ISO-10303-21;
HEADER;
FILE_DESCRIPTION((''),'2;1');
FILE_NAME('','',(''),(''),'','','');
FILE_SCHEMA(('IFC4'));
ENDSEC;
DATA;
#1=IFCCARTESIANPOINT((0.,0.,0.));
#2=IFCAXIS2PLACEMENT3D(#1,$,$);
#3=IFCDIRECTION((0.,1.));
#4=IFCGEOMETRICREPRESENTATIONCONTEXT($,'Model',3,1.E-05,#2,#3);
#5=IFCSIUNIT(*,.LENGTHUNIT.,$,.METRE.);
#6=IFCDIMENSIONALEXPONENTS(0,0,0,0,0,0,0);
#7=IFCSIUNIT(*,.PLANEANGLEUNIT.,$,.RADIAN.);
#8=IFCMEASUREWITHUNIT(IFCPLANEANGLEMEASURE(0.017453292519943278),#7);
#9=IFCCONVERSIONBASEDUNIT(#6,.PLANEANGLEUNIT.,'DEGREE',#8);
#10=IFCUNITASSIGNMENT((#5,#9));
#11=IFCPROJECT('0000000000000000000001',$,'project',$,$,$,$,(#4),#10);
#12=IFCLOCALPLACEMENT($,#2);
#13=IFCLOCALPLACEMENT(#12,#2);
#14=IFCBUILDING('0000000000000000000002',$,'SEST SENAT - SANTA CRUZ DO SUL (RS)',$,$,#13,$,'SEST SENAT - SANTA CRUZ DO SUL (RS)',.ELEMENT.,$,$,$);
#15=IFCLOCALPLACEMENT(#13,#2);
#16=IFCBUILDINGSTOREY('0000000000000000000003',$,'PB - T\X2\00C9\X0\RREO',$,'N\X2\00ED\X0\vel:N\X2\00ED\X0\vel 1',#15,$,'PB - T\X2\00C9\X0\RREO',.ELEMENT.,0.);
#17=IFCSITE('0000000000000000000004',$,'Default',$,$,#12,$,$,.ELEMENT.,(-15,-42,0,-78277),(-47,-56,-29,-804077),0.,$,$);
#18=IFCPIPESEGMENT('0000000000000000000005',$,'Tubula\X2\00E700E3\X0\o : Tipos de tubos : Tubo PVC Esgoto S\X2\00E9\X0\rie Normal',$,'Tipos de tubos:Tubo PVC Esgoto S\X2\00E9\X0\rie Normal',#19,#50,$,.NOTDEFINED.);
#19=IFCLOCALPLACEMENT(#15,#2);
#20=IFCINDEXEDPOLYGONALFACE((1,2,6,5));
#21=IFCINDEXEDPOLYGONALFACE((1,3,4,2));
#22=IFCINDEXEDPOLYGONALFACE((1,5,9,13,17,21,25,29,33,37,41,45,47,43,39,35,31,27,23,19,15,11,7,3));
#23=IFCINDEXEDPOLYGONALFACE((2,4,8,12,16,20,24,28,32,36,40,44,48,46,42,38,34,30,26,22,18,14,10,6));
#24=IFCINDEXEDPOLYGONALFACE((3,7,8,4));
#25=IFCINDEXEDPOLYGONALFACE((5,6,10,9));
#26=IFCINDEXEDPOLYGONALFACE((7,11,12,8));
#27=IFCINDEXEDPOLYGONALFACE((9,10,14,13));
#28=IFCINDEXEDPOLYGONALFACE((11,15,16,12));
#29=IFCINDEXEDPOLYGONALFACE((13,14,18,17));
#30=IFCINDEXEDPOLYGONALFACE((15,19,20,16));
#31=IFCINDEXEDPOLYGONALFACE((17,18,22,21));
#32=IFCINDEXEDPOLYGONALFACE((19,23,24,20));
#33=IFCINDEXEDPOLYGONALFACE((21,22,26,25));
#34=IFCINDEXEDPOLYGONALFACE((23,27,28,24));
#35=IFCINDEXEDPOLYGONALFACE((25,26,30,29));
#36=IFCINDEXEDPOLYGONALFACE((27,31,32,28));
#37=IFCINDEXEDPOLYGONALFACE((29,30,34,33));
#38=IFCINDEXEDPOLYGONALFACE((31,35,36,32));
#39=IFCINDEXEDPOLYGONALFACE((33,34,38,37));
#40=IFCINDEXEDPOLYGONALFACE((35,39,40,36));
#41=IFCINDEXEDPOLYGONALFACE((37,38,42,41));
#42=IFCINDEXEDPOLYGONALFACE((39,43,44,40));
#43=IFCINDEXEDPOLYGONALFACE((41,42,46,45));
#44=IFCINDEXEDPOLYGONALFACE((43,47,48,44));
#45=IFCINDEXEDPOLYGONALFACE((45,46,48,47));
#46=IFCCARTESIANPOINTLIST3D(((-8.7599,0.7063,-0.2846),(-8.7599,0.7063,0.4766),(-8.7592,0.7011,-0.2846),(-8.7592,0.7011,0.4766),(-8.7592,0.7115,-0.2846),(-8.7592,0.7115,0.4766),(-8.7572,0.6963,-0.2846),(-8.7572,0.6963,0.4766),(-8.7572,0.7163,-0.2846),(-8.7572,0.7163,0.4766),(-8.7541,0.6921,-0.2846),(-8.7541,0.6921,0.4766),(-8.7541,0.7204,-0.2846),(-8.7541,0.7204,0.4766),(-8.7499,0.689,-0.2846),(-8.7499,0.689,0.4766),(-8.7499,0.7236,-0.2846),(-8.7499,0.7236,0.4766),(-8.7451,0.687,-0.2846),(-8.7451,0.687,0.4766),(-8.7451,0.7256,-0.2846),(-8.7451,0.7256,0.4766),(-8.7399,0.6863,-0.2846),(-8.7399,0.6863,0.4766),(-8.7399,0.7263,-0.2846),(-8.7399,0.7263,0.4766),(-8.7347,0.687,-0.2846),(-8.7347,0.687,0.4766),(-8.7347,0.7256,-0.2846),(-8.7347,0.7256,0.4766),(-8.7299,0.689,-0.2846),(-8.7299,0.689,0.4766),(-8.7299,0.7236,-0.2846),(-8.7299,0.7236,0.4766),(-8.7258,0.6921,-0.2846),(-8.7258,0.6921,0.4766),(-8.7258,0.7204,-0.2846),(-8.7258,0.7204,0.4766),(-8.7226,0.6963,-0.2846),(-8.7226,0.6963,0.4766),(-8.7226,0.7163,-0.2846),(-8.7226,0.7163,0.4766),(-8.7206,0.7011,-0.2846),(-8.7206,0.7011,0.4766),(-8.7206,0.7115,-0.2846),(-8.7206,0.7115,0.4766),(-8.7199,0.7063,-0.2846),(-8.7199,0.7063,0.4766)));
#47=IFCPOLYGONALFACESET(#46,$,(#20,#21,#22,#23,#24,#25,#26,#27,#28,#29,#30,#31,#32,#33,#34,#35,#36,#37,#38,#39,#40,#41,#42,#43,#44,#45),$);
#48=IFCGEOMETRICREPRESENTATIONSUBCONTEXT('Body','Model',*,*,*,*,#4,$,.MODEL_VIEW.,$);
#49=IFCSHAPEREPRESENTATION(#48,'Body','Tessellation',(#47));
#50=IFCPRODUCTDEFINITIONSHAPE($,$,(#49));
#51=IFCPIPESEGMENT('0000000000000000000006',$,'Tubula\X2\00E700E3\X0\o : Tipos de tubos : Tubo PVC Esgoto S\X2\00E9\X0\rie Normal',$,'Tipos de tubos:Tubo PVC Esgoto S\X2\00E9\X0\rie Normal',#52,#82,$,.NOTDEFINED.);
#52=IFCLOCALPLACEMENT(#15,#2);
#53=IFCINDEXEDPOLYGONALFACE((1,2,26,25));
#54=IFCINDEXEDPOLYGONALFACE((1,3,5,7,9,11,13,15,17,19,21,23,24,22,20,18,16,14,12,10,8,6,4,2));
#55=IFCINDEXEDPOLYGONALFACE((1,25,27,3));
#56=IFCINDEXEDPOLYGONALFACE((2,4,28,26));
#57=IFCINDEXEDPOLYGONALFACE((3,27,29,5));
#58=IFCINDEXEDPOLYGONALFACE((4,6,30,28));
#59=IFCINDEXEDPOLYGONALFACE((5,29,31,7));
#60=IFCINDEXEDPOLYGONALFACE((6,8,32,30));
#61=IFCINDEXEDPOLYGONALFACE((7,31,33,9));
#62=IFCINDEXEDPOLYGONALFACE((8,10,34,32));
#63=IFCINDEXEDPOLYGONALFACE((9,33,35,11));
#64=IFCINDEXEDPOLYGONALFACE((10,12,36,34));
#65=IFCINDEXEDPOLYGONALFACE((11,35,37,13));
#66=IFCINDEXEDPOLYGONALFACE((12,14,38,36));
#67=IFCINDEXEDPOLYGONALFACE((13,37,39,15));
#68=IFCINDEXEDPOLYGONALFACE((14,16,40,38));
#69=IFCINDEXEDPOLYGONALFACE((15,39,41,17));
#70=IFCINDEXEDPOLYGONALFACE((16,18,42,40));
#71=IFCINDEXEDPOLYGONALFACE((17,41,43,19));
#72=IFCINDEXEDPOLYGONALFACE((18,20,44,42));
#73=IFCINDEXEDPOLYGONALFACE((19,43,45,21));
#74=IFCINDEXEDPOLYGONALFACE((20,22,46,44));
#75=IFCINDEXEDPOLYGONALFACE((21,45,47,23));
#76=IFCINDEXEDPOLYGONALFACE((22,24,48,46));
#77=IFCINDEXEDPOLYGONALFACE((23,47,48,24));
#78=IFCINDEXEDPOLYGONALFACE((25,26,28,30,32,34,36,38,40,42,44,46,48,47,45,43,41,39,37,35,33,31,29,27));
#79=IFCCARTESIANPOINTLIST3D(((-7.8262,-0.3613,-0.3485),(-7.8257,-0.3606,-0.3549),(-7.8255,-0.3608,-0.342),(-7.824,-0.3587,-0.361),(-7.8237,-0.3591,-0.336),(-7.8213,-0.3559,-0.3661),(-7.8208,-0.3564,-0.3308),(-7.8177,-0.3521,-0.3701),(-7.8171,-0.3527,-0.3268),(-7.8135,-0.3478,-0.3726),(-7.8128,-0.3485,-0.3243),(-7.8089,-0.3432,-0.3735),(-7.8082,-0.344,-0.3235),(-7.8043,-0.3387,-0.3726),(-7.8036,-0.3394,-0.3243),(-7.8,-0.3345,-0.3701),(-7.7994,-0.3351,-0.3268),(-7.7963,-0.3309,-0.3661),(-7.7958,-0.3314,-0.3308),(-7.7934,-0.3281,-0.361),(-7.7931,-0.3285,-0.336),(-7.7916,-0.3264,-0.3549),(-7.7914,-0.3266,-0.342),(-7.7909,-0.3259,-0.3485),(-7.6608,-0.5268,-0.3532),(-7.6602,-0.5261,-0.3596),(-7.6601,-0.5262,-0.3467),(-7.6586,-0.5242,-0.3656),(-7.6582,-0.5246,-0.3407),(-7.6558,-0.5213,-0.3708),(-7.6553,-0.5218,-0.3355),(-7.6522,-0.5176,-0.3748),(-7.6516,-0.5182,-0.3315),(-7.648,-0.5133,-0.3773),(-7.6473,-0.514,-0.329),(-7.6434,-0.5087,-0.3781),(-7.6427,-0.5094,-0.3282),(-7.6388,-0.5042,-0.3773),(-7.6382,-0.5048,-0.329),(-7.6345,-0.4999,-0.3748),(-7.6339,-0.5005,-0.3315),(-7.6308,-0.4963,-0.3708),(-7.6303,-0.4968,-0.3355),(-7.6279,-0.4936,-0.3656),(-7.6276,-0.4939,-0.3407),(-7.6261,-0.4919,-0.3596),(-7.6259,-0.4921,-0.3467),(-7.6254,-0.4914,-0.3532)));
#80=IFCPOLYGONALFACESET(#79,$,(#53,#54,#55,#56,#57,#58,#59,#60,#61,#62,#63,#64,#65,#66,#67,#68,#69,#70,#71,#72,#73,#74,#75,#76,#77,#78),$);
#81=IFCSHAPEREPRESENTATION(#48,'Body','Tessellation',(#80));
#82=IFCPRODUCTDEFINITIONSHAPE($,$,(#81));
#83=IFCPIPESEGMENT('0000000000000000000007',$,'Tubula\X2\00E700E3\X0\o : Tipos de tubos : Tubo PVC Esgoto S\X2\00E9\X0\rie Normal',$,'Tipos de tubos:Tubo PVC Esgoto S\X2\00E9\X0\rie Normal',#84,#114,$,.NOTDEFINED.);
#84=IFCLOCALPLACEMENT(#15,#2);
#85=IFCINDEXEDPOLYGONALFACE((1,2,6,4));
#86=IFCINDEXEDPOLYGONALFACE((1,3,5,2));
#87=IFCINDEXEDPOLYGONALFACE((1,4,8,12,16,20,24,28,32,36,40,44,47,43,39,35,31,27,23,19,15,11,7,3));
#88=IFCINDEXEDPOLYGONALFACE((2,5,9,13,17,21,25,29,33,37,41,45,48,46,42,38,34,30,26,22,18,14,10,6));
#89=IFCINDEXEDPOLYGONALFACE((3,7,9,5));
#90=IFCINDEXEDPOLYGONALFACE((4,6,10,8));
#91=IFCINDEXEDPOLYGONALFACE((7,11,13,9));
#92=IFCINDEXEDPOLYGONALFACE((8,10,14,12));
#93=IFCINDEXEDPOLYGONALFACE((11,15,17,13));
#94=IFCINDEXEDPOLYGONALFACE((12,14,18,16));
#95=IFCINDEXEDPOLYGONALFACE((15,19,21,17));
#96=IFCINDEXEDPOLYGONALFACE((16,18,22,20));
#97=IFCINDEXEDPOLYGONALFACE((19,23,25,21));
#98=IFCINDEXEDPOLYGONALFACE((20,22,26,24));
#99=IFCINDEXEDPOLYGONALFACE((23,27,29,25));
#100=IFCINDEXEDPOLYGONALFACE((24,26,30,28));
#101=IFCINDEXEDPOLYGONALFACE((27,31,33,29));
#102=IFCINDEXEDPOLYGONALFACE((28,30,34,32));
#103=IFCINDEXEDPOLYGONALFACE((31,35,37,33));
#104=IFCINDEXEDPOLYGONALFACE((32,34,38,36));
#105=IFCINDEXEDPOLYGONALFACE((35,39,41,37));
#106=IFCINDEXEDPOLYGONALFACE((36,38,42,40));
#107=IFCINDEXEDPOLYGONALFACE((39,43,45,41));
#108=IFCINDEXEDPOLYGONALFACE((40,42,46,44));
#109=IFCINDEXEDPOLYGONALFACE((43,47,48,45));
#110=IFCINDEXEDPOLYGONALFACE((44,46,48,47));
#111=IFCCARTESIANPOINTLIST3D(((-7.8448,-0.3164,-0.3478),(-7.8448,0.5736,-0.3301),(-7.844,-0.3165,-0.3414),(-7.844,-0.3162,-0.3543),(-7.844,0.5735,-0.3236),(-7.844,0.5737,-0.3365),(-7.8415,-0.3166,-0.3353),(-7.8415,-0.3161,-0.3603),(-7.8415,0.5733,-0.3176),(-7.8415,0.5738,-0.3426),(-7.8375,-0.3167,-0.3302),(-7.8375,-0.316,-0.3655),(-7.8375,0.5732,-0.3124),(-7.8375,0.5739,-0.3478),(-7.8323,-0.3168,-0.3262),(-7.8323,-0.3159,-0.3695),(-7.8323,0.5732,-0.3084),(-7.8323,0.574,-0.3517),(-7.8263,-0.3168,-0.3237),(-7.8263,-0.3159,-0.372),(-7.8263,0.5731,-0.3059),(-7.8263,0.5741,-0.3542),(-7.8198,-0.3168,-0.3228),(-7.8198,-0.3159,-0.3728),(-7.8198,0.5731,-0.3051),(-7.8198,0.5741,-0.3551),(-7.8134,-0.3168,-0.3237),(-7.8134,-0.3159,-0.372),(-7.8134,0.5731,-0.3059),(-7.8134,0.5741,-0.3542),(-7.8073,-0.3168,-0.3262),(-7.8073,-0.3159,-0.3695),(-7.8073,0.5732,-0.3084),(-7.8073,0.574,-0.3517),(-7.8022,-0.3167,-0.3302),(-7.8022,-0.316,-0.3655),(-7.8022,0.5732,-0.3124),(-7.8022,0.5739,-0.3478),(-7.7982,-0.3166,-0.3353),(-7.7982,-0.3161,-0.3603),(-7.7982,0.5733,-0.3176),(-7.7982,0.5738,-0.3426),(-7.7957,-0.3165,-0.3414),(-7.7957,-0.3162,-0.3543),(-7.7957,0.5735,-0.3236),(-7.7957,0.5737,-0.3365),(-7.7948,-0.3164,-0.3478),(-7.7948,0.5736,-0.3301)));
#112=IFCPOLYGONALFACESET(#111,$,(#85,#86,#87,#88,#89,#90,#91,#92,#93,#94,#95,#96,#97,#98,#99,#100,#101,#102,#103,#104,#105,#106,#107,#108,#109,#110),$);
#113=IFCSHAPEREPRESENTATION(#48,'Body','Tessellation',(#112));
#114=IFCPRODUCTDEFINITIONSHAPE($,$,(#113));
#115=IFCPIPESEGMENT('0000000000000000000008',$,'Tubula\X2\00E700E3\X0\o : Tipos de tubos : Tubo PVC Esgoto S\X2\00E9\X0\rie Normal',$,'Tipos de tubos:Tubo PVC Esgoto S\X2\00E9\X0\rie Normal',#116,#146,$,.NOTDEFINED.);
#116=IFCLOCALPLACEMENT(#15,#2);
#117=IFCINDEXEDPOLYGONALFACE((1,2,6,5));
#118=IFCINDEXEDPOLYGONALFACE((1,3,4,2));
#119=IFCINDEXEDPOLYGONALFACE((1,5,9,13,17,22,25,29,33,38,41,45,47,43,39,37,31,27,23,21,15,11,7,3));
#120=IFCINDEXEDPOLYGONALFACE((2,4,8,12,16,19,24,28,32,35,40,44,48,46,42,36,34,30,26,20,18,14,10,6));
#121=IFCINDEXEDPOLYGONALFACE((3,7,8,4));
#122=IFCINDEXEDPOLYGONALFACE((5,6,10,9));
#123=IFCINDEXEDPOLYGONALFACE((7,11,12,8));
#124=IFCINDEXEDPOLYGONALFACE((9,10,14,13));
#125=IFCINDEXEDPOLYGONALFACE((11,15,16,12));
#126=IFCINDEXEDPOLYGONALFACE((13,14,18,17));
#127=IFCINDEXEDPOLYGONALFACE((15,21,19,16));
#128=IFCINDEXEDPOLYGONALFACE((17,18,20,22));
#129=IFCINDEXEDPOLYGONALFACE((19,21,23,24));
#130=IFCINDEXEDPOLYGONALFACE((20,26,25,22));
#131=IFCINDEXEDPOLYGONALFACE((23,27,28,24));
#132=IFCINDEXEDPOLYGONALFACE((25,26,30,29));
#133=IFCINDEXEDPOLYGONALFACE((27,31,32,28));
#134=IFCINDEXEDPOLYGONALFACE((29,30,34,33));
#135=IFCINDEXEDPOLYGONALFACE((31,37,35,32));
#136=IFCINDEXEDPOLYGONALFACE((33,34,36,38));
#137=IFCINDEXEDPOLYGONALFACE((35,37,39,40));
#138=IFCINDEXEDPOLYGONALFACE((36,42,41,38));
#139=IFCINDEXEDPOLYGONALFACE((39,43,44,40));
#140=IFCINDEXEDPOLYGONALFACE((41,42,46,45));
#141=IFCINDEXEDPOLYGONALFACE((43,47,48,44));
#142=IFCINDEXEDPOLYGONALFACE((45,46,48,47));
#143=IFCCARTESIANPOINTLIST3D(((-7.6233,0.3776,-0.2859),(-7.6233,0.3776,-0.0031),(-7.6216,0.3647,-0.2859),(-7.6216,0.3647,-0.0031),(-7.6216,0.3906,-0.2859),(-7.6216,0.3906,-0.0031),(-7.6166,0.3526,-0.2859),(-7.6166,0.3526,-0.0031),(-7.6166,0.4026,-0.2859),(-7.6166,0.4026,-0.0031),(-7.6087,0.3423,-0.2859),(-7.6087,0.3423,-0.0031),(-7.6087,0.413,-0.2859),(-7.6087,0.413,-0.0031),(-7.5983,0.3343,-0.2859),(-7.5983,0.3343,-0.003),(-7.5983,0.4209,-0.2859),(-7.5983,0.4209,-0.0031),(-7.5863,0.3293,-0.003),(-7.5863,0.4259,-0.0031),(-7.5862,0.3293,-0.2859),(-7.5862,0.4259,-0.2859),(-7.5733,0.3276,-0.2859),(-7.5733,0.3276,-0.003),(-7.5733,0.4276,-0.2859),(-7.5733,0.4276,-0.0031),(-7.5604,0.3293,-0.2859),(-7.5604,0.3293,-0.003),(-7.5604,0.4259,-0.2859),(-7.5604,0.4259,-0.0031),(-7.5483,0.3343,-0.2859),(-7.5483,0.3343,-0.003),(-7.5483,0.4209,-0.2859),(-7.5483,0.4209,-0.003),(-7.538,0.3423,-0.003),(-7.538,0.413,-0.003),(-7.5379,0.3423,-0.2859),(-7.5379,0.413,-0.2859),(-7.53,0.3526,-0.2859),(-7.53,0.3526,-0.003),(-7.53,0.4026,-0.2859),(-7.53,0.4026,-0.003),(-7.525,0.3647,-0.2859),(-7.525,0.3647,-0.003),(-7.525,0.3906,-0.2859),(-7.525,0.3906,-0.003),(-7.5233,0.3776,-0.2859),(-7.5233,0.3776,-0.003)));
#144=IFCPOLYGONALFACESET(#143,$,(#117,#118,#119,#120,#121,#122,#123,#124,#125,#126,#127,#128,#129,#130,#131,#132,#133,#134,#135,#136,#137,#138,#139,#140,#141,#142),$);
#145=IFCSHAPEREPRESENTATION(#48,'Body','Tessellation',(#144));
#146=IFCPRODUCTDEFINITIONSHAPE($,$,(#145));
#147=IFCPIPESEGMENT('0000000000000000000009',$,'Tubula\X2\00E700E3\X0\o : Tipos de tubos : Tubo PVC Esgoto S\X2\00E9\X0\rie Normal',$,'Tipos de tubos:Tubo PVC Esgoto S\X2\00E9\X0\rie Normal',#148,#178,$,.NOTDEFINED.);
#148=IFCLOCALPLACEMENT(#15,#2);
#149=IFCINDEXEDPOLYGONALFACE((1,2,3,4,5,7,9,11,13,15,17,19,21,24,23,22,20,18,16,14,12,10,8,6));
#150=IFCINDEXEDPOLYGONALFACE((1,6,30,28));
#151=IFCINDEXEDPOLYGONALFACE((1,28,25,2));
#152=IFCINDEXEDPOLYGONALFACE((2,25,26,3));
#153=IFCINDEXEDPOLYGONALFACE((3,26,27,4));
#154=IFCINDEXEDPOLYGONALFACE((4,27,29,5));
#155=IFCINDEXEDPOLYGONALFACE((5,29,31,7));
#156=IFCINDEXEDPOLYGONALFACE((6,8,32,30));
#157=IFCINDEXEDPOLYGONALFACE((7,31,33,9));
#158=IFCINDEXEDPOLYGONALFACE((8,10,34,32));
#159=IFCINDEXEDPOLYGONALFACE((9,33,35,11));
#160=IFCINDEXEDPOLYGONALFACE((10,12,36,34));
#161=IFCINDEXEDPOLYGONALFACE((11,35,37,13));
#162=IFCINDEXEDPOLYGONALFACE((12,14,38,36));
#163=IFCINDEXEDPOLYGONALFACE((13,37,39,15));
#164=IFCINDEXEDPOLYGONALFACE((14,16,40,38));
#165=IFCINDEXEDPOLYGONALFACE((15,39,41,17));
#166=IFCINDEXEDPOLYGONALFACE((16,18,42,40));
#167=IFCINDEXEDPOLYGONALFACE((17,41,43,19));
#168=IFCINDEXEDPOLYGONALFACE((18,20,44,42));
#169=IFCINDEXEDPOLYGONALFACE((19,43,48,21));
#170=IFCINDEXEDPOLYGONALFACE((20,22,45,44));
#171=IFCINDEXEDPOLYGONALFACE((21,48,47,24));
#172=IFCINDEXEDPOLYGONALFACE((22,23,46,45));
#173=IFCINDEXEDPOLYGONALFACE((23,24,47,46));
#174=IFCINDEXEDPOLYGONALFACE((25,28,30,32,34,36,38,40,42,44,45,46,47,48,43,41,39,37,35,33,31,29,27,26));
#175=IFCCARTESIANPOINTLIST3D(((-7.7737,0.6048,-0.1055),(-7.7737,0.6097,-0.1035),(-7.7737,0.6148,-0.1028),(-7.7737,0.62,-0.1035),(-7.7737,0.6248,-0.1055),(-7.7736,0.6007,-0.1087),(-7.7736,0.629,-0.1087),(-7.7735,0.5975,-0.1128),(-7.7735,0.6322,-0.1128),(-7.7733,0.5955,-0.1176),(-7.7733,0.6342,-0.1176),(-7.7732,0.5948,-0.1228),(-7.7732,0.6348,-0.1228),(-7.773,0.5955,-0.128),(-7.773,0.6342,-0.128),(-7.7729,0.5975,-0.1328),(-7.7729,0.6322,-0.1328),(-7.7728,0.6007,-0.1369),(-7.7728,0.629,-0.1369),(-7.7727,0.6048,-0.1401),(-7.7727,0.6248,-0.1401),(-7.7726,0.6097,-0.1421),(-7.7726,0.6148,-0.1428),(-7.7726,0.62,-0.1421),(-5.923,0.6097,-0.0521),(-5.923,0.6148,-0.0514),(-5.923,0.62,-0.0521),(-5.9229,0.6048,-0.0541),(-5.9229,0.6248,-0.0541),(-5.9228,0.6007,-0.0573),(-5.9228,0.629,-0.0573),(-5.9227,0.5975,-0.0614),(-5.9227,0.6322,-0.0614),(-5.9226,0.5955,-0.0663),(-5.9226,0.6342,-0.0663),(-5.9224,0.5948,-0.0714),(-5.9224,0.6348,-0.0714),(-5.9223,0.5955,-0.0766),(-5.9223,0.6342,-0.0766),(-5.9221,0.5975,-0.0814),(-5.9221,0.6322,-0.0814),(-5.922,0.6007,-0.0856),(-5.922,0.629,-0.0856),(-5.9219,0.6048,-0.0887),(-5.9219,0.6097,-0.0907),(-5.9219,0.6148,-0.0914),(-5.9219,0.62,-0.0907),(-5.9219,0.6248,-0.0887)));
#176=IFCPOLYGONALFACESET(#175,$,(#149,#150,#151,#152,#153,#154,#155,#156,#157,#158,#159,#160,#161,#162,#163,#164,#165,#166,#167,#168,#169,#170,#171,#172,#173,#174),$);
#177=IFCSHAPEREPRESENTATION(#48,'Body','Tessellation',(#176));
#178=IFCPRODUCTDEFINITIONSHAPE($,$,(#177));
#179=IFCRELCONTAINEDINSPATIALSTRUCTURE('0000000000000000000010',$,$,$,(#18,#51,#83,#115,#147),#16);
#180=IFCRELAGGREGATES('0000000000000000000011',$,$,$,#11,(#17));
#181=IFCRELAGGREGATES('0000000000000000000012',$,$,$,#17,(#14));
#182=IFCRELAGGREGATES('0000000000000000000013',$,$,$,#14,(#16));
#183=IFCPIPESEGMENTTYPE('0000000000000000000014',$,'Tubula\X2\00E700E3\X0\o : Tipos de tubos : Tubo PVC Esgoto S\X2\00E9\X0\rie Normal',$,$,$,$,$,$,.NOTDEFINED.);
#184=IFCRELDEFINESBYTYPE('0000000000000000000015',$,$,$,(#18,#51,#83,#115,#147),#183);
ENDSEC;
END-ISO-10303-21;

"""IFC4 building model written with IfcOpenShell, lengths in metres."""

from ifc_helpers import new_model, entity, si_unit, converted_unit, direction, frame, origin, place, context, subcontext, project, spatial, arc, indexed_curve, outline, extrude, type_object, element, save


model = new_model("IFC4")

# Units and contexts
model_context = context("Model", 3, precision=1e-05, world=origin(), true_north=direction((0.0, 1.0)))
body_context = subcontext(model_context, "Body", "Model", "MODEL_VIEW")
ifc_project = project(units=[si_unit("LENGTHUNIT", "METRE"), converted_unit("PLANEANGLEUNIT", "DEGREE", entity("IfcPlaneAngleMeasure", 0.017453292519943278), si_unit("PLANEANGLEUNIT", "RADIAN"), dimensions=[0, 0, 0, 0, 0, 0, 0])], contexts=[model_context])

# Site, building, storey
site_placement = place(None, origin())
site = spatial("IfcSite", under=ifc_project, at=site_placement, Name="Default", CompositionType="ELEMENT", RefLatitude=(-15, -42, 0, -78277), RefLongitude=(-47, -56, -29, -804077), RefElevation=0.0)
building_placement = place(site_placement, origin())
building = spatial("IfcBuilding", under=site, at=building_placement, Name="SEST SENAT - SANTA CRUZ DO SUL (RS)", LongName="SEST SENAT - SANTA CRUZ DO SUL (RS)", CompositionType="ELEMENT")
storey_placement = place(building_placement, origin())
storey = spatial("IfcBuildingStorey", under=building, at=storey_placement, Name="PB - TÉRREO", ObjectType="Nível:Nível 1", LongName="PB - TÉRREO", CompositionType="ELEMENT", Elevation=0.0)

# Pipe segments
pipe_segment_type_1 = type_object("IfcPipeSegmentType", Name="Tubulação : Tipos de tubos : Tubo PVC Esgoto Série Normal", PredefinedType="NOTDEFINED")
pipe_segment_1_placement = place(storey_placement, frame((-8.7615, 0.6847, -0.2846)))
element("IfcPipeSegment", 1, at=pipe_segment_1_placement, inside=storey, type_object=pipe_segment_type_1, Name="Tubulação : Tipos de tubos : Tubo PVC Esgoto Série Normal", ObjectType="Tipos de tubos:Tubo PVC Esgoto Série Normal", PredefinedType="NOTDEFINED", context=body_context, shape_type="SweptSolid", body=[
    extrude(outline(indexed_curve([(0.02, 0.0), (0.0141, 0.0141), (0.0, 0.02), (-0.0141, 0.0141), (-0.02, 0.0), (-0.0141, -0.0141), (0.0, -0.02), (0.0141, -0.0141)], segments=[arc(1, 2, 3), arc(3, 4, 5), arc(5, 6, 7), arc(7, 8, 1)], self_intersect=False)), frame((0.0216, 0.0216, 0.0), z_axis=(0.0, 0.0, 1.0), x_axis=(-1.0, 0.0, 0.0)), (0.0, 0.0, 1.0), 0.7613),
])
pipe_segment_2_placement = place(storey_placement, frame((-7.8278, -0.5283, -0.3219)))
element("IfcPipeSegment", 2, at=pipe_segment_2_placement, inside=storey, type_object=pipe_segment_type_1, Name="Tubulação : Tipos de tubos : Tubo PVC Esgoto Série Normal", ObjectType="Tipos de tubos:Tubo PVC Esgoto Série Normal", PredefinedType="NOTDEFINED", context=body_context, shape_type="SweptSolid", body=[
    extrude(outline(indexed_curve([(0.025, 0.0), (0.0177, 0.0177), (0.0, 0.025), (-0.0177, 0.0177), (-0.025, 0.0), (-0.0177, -0.0177), (0.0, -0.025), (0.0177, -0.0177)], segments=[arc(1, 2, 3), arc(3, 4, 5), arc(5, 6, 7), arc(7, 8, 1)], self_intersect=False)), frame((0.0193, 0.1847, -0.0266), z_axis=(0.706948, -0.706983, -0.019996), x_axis=(-0.707124, -0.707089, 0.0)), (0.0, 0.0, 1.0), 0.2341),
])
pipe_segment_3_placement = place(storey_placement, frame((-7.8464, -0.3184, -0.3744)))
element("IfcPipeSegment", 3, at=pipe_segment_3_placement, inside=storey, type_object=pipe_segment_type_1, Name="Tubulação : Tipos de tubos : Tubo PVC Esgoto Série Normal", ObjectType="Tipos de tubos:Tubo PVC Esgoto Série Normal", PredefinedType="NOTDEFINED", context=body_context, shape_type="SweptSolid", body=[
    extrude(outline(indexed_curve([(0.025, 0.0), (0.0177, 0.0177), (0.0, 0.025), (-0.0177, 0.0177), (-0.025, 0.0), (-0.0177, -0.0177), (0.0, -0.025), (0.0177, -0.0177)], segments=[arc(1, 2, 3), arc(3, 4, 5), arc(5, 6, 7), arc(7, 8, 1)], self_intersect=False)), frame((0.0266, 0.0021, 0.0266), z_axis=(0.0, 0.999801, 0.019946), x_axis=(1.0, 0.0, 0.0)), (0.0, 0.0, 1.0), 0.8901),
])
pipe_segment_4_placement = place(storey_placement, frame((-7.6249, 0.326, -0.003)))
element("IfcPipeSegment", 4, at=pipe_segment_4_placement, inside=storey, type_object=pipe_segment_type_1, Name="Tubulação : Tipos de tubos : Tubo PVC Esgoto Série Normal", ObjectType="Tipos de tubos:Tubo PVC Esgoto Série Normal", PredefinedType="NOTDEFINED", context=body_context, shape_type="SweptSolid", body=[
    extrude(outline(indexed_curve([(0.05, 0.0), (0.0354, 0.0354), (0.0, 0.05), (-0.0354, 0.0354), (-0.05, 0.0), (-0.0354, -0.0354), (0.0, -0.05), (0.0354, -0.0354)], segments=[arc(1, 2, 3), arc(3, 4, 5), arc(5, 6, 7), arc(7, 8, 1)], self_intersect=False)), frame((0.0516, 0.0516, -0.2829), z_axis=(-0.000066, 0.000034, 1.0), x_axis=(-1.0, 0.0, -0.000066)), (0.0, 0.0, 1.0), 0.2829),
])
pipe_segment_5_placement = place(storey_placement, frame((-7.7753, 0.5932, -0.1444)))
element("IfcPipeSegment", 5, at=pipe_segment_5_placement, inside=storey, type_object=pipe_segment_type_1, Name="Tubulação : Tipos de tubos : Tubo PVC Esgoto Série Normal", ObjectType="Tipos de tubos:Tubo PVC Esgoto Série Normal", PredefinedType="NOTDEFINED", context=body_context, shape_type="SweptSolid", body=[
    extrude(outline(indexed_curve([(0.02, 0.0), (0.0141, 0.0141), (0.0, 0.02), (-0.0141, 0.0141), (-0.02, 0.0), (-0.0141, -0.0141), (0.0, -0.02), (0.0141, -0.0141)], segments=[arc(1, 2, 3), arc(3, 4, 5), arc(5, 6, 7), arc(7, 8, 1)], self_intersect=False)), frame((0.0022, 0.0216, 0.0216), z_axis=(0.999615, 0.0, 0.027744), x_axis=(0.0, 1.0, 0.0)), (0.0, 0.0, 1.0), 1.8515),
])

save(model, "model.ifc")
